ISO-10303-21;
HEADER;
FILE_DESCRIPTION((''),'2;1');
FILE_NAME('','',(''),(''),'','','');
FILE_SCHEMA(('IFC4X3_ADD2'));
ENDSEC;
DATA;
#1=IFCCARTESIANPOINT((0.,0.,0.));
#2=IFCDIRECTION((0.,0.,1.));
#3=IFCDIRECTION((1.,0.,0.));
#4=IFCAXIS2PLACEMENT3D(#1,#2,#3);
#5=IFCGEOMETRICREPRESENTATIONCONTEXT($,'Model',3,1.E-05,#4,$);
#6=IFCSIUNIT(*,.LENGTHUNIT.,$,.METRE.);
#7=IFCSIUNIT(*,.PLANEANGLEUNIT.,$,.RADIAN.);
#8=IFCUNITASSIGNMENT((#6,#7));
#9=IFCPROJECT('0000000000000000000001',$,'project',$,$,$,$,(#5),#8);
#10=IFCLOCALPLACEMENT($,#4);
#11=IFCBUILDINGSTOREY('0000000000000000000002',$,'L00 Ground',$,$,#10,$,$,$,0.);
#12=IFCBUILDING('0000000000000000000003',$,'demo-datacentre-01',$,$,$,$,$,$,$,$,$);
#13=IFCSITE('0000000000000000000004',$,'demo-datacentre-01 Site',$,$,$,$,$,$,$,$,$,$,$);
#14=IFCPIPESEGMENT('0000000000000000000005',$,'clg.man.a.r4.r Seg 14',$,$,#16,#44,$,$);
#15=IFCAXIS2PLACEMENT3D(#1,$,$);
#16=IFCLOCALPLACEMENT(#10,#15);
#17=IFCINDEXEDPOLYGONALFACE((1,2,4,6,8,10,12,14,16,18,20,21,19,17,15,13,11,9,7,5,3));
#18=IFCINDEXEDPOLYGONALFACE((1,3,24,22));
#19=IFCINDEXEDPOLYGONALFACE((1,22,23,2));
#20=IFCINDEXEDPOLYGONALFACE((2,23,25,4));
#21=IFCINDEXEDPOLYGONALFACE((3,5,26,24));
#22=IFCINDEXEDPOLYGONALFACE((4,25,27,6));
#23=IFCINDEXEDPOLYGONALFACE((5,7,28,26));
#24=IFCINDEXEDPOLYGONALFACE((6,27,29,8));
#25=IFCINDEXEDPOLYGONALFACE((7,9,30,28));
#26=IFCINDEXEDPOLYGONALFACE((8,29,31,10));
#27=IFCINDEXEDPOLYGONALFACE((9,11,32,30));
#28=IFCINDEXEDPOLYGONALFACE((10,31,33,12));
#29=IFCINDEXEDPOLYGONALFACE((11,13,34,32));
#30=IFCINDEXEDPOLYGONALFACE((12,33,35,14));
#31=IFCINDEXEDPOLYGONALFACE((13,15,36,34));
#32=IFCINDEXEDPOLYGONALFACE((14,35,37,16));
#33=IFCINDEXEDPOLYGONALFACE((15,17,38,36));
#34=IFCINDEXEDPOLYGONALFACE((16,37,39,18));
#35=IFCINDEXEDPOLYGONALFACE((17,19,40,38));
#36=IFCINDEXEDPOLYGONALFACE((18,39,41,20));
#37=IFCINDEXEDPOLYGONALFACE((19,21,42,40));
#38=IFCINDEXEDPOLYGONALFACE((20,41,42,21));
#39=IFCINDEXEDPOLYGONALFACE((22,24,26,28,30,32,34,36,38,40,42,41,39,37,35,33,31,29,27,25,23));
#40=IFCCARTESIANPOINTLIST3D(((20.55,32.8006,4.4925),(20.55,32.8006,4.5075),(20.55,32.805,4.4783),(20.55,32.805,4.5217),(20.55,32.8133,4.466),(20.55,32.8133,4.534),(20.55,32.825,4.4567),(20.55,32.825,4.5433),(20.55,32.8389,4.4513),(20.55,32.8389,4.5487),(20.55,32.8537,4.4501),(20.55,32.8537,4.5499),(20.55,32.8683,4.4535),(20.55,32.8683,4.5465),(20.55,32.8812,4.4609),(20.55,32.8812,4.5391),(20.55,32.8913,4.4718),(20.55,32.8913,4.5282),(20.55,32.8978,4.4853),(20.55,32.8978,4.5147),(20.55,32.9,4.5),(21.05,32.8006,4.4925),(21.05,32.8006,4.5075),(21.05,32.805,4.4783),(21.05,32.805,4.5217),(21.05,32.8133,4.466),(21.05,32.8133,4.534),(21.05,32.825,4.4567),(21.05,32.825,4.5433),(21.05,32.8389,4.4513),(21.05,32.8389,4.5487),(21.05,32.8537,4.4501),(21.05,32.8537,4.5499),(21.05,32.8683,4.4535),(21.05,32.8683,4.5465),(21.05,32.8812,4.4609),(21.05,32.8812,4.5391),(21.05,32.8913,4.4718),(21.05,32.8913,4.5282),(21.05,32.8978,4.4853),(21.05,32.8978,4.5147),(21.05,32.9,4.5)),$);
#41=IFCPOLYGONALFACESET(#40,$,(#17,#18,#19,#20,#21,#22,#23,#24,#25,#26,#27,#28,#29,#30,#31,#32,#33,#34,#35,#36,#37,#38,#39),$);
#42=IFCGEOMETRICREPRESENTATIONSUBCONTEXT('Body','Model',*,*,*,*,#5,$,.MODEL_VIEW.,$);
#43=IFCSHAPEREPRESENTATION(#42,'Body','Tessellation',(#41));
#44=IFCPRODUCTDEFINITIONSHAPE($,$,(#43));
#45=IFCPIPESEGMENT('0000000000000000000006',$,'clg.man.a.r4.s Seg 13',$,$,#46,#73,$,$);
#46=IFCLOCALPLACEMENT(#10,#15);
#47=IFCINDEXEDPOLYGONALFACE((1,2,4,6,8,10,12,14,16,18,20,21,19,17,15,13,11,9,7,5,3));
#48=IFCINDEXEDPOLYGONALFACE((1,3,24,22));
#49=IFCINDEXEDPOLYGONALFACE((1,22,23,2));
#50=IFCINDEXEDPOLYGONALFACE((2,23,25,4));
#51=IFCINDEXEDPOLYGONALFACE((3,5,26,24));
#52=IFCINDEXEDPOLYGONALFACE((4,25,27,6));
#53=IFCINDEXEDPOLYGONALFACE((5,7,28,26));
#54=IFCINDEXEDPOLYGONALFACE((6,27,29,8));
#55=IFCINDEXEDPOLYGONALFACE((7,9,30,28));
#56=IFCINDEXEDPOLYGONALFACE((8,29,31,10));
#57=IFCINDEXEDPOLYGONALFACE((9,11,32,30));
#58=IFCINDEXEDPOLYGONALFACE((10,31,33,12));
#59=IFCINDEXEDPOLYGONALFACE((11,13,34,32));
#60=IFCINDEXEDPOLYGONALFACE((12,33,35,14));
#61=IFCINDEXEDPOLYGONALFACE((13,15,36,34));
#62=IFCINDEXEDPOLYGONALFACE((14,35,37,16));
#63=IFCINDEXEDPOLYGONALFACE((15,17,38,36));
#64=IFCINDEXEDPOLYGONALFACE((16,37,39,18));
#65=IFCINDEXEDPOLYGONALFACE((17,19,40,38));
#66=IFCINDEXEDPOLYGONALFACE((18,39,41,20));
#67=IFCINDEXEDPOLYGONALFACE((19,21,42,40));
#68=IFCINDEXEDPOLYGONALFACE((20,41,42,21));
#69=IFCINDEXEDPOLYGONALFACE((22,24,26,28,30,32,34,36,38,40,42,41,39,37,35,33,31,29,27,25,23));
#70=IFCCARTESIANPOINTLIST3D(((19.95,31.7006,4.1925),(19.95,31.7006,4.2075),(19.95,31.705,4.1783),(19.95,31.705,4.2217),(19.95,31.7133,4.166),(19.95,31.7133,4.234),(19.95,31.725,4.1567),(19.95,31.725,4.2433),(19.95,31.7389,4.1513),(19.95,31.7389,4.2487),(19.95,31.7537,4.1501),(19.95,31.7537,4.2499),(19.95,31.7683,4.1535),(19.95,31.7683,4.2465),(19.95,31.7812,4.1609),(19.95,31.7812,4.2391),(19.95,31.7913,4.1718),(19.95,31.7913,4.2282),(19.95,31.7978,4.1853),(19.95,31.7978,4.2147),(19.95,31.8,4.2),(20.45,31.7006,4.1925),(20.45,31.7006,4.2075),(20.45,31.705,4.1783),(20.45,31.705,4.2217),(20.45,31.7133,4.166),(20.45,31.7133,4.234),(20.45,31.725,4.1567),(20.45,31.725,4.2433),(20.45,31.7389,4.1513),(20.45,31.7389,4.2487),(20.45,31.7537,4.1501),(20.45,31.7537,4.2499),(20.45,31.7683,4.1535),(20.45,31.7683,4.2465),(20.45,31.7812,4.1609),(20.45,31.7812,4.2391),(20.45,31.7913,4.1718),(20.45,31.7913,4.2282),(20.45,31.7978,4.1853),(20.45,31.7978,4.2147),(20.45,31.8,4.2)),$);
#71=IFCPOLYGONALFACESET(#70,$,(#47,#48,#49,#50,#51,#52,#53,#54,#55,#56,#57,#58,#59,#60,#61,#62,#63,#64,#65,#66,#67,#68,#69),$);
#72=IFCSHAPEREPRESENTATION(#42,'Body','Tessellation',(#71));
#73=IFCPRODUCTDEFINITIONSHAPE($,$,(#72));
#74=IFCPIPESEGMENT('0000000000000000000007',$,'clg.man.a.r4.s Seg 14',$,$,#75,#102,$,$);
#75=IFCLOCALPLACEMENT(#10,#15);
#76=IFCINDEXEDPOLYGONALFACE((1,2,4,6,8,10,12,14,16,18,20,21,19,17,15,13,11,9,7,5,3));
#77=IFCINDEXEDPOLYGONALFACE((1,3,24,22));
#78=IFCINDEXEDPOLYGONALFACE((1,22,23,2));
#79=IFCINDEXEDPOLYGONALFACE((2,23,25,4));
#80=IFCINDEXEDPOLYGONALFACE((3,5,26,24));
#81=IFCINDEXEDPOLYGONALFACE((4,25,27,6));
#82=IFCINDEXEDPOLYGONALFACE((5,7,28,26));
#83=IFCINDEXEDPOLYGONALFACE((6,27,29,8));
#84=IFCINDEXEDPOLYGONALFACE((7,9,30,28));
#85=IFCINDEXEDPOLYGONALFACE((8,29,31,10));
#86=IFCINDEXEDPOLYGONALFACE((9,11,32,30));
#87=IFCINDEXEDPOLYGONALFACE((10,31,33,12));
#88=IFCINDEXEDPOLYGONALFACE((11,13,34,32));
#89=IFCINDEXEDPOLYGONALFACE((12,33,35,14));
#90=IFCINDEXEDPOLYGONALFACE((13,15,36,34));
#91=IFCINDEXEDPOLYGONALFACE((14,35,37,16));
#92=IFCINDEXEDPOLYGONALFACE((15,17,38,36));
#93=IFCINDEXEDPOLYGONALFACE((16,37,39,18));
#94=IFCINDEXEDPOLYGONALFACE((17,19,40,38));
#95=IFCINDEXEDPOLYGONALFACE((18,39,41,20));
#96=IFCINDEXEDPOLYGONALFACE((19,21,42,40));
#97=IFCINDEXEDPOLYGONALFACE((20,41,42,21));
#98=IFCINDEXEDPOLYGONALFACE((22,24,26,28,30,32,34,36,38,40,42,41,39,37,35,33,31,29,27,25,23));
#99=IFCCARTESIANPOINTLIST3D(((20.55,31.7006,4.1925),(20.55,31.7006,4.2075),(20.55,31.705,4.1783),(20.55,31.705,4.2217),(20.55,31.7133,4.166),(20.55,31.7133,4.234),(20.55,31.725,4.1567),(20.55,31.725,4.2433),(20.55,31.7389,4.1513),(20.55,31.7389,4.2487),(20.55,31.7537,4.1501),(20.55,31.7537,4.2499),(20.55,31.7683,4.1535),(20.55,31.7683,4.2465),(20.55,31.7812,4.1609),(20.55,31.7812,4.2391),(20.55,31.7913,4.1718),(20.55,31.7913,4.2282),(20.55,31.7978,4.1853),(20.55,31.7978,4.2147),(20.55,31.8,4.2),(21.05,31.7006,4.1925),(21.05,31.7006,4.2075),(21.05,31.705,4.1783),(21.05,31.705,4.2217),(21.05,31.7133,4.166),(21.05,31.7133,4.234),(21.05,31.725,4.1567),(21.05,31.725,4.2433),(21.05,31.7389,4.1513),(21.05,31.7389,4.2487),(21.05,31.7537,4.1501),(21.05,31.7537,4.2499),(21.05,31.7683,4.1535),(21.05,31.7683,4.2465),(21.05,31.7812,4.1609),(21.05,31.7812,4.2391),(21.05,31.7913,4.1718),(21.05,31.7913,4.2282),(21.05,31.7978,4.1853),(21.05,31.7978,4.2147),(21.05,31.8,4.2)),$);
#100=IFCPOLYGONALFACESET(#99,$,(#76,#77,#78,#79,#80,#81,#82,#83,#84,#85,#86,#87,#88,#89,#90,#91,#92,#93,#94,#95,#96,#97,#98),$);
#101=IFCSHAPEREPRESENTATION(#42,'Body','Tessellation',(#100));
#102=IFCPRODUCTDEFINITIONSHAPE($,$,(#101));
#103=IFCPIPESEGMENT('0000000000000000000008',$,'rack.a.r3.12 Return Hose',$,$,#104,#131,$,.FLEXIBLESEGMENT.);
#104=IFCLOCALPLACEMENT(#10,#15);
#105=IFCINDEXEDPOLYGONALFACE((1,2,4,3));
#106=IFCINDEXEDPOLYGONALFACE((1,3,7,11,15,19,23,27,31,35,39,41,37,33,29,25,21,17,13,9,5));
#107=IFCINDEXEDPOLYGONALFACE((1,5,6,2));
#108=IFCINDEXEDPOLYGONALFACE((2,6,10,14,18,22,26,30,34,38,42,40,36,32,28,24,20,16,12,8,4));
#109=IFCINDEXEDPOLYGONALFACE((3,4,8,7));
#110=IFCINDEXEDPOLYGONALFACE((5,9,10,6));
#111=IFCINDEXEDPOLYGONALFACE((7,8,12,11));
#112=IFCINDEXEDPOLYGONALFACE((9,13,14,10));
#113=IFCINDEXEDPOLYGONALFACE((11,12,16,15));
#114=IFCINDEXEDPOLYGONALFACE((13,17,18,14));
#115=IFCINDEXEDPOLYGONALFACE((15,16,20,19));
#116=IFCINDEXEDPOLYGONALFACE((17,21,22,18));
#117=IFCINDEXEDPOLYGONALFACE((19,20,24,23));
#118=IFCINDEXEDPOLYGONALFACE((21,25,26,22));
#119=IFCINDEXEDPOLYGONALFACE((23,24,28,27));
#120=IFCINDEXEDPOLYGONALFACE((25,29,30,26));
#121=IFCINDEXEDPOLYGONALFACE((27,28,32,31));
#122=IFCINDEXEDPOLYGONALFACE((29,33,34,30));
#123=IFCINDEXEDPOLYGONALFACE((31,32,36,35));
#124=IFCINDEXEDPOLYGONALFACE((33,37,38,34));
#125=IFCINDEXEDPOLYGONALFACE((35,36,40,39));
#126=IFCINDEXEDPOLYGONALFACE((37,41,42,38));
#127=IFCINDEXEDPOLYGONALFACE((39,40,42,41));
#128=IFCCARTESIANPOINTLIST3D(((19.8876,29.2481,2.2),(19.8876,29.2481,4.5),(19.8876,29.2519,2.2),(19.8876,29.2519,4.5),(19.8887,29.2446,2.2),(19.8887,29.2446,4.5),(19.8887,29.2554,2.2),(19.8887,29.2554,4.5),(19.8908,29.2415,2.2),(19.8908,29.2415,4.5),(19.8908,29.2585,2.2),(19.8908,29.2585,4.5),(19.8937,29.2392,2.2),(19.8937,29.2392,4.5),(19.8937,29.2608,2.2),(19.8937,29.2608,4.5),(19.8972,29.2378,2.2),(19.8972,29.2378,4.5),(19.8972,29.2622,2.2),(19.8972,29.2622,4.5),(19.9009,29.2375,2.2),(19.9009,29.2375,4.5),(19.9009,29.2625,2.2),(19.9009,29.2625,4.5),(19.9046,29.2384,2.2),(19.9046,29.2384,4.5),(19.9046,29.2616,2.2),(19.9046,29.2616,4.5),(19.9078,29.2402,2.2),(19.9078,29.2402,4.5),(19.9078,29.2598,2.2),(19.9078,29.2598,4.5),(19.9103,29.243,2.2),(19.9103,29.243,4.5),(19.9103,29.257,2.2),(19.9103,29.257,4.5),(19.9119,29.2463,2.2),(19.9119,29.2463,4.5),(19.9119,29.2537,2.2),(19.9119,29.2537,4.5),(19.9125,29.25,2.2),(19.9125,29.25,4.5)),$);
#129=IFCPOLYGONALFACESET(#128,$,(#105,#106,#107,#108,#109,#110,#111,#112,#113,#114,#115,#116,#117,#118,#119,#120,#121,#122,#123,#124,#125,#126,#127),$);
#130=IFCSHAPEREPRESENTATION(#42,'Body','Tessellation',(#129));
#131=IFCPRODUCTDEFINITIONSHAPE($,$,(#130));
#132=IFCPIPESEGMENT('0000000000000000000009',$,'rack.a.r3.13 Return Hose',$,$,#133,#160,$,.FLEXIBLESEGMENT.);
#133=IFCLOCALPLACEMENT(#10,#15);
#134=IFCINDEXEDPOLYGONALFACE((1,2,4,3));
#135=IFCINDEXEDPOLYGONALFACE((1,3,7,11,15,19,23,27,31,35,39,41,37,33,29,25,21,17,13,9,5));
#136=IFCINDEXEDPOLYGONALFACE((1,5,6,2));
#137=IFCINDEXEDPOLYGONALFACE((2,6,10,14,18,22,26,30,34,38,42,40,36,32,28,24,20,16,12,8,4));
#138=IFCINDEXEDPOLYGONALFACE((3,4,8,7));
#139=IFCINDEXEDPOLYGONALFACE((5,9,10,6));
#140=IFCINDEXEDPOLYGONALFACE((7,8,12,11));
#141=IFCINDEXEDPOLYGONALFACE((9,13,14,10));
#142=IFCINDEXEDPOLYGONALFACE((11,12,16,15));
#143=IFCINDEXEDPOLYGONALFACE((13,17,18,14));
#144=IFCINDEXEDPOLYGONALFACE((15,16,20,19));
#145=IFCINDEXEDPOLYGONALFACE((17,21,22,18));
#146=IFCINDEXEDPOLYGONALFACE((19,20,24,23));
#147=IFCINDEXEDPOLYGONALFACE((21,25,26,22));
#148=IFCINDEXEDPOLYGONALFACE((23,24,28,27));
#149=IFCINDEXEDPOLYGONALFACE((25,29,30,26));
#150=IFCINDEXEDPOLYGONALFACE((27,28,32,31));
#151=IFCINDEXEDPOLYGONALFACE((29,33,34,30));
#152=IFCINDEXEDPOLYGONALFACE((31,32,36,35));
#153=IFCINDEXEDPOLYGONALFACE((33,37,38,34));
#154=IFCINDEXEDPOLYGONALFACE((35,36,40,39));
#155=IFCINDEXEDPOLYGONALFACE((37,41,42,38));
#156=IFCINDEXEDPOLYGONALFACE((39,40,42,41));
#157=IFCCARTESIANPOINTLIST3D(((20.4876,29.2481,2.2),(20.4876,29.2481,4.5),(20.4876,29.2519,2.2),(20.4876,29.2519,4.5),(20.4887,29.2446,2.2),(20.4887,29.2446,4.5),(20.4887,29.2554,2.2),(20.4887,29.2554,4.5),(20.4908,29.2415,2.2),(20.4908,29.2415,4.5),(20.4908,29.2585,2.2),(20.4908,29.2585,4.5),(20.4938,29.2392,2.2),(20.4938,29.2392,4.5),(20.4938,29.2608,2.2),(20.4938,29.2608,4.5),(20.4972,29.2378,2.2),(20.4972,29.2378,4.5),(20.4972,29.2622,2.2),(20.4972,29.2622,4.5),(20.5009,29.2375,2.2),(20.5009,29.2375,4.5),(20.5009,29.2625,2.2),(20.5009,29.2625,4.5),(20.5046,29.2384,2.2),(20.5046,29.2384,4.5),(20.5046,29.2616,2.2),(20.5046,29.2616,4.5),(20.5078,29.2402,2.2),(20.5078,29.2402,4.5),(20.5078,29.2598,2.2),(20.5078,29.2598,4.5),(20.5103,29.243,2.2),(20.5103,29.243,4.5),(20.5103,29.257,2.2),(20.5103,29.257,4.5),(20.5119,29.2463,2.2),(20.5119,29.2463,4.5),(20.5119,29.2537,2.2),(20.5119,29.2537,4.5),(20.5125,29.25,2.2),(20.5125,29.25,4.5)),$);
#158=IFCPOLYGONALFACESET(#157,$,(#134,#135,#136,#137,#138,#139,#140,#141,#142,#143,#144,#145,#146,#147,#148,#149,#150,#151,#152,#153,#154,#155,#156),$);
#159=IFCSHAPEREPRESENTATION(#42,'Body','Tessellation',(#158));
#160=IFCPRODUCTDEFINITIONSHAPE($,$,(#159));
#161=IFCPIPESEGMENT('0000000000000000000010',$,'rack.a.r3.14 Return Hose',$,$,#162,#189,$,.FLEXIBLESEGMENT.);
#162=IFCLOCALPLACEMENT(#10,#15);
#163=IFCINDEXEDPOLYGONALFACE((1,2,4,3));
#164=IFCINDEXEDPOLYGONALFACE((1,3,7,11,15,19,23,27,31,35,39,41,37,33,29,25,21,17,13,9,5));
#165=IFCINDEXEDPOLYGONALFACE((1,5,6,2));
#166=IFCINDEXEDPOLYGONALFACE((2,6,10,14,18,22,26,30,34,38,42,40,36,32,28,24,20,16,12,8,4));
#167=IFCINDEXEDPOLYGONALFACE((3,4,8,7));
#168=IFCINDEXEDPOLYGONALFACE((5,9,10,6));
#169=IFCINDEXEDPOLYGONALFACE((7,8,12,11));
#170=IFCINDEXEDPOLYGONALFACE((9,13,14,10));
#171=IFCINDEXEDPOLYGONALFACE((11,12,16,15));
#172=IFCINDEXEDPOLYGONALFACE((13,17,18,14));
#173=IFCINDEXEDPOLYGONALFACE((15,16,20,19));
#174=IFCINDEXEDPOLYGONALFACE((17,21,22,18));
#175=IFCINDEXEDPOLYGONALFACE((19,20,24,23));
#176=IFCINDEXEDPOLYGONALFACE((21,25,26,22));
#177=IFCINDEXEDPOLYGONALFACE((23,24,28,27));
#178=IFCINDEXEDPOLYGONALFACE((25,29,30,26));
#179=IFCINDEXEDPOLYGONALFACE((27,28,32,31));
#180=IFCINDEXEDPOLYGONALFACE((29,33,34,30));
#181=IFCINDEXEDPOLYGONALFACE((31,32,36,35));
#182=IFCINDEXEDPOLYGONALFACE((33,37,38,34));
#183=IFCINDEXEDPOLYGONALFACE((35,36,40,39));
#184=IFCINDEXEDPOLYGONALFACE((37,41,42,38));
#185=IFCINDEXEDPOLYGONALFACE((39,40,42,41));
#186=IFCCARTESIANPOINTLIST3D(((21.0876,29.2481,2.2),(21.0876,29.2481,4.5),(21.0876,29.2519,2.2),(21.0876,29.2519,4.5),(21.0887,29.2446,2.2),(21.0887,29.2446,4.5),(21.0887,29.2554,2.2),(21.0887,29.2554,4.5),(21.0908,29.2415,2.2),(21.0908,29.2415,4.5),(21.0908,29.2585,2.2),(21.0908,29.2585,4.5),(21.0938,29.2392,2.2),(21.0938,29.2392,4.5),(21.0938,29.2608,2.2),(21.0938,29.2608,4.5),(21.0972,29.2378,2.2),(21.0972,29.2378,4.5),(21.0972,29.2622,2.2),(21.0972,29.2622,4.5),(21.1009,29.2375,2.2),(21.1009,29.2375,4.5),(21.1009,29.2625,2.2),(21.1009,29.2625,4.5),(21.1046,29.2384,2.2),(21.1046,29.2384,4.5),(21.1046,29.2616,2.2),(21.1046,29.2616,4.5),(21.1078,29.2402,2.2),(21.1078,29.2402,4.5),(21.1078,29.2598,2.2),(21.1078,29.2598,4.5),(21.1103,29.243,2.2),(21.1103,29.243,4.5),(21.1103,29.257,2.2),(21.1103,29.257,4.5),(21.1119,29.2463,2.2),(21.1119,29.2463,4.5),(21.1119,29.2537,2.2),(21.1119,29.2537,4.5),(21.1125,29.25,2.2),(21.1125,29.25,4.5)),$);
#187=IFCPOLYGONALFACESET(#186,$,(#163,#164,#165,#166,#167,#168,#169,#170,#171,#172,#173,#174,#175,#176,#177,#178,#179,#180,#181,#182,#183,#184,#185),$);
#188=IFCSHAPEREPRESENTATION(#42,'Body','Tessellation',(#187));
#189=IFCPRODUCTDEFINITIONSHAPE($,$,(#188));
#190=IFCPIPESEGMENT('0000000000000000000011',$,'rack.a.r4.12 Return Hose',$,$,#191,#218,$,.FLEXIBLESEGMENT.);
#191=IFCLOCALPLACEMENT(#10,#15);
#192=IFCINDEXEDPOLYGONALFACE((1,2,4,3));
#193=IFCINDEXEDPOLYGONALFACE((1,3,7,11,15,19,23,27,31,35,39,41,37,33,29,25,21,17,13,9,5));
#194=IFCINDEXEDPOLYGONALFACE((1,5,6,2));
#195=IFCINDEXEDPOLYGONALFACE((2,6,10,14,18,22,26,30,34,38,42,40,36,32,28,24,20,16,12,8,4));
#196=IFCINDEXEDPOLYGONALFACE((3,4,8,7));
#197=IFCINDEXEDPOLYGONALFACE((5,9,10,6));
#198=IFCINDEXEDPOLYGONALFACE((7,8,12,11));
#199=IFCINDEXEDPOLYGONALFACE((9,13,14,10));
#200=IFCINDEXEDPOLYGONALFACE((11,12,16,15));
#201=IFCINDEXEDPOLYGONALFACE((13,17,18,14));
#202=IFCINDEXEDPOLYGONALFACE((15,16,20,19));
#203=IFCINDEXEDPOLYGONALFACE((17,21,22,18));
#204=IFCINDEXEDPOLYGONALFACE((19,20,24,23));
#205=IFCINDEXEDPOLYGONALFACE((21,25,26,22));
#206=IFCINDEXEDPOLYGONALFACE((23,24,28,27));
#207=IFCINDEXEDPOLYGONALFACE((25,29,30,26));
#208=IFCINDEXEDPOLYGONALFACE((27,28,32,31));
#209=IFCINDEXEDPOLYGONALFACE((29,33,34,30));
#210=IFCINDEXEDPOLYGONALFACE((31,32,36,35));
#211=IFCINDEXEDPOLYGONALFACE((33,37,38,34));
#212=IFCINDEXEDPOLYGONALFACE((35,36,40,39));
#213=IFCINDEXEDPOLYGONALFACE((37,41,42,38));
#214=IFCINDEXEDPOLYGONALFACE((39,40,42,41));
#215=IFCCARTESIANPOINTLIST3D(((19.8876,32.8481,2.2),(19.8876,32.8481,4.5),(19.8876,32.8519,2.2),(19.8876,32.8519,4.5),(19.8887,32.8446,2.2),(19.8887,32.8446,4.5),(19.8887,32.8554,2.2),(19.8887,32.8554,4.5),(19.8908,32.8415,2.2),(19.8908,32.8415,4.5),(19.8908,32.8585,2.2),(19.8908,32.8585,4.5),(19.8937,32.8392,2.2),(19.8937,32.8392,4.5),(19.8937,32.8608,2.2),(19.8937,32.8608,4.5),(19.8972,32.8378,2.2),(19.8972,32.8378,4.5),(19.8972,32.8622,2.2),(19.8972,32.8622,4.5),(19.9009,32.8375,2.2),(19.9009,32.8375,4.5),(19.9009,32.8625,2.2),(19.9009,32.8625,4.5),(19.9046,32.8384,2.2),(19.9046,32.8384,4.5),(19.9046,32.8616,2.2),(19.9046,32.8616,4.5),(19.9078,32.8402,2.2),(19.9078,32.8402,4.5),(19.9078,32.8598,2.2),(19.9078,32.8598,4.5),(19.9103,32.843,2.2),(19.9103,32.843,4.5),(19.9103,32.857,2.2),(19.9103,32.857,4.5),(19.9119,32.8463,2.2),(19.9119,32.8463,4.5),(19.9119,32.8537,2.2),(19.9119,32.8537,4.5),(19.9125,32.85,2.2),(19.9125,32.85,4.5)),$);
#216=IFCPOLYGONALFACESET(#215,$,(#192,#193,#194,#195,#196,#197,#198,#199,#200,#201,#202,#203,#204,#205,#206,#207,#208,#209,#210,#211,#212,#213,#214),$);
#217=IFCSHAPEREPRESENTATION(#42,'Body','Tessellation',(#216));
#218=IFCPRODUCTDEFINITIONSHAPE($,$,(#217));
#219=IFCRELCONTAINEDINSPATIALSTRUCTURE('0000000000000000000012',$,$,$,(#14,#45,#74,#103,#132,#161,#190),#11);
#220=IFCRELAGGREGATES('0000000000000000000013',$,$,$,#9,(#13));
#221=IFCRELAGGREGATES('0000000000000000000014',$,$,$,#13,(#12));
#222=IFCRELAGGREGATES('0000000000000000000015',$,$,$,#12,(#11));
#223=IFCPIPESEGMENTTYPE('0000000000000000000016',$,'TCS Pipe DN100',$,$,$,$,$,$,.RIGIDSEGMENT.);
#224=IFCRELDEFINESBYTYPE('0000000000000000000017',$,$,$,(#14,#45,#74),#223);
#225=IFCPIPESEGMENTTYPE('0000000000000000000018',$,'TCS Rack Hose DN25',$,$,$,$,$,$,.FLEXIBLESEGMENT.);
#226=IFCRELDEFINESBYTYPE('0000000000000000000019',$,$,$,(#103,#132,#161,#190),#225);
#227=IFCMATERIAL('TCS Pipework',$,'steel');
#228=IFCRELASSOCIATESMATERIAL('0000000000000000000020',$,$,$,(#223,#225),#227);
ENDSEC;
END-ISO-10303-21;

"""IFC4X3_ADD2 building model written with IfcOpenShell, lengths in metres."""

from ifc_helpers import new_model, si_unit, frame, origin_with_axes, place, context, subcontext, project, spatial, circle, extrude, material, type_object, element, save


model = new_model("IFC4X3_ADD2")

# Units and contexts
model_context = context("Model", 3, precision=1e-05, world=origin_with_axes())
body_context = subcontext(model_context, "Body", "Model", "MODEL_VIEW")
ifc_project = project(units=[si_unit("LENGTHUNIT", "METRE"), si_unit("PLANEANGLEUNIT", "RADIAN")], contexts=[model_context])

# Site, building, storey
site = spatial("IfcSite", under=ifc_project, Name="demo-datacentre-01 Site")
building = spatial("IfcBuilding", under=site, Name="demo-datacentre-01")
storey_placement = place(None, origin_with_axes())
storey = spatial("IfcBuildingStorey", under=building, at=storey_placement, Name="L00 Ground", Elevation=0.0)

# Shared definitions
ifc_material = material(Name="TCS Pipework", Category="steel")

# Pipe segments
pipe_segment_type_1 = type_object("IfcPipeSegmentType", Name="TCS Pipe DN100", PredefinedType="RIGIDSEGMENT", material=ifc_material)
for number, where, z_axis, x_axis, name in (
    (1, (20.55, 32.85, 4.5), (1.0, 0.0, 0.0), (0.0, 1.0, 0.0), "clg.man.a.r4.r Seg 14"),
    (2, (19.95, 31.75, 4.2), (1.0, 0.0, 0.0), (0.0, 1.0, 0.0), "clg.man.a.r4.s Seg 13"),
    (3, (20.55, 31.75, 4.2), (1.0, 0.0, 0.0), (0.0, 1.0, 0.0), "clg.man.a.r4.s Seg 14"),
):
    element("IfcPipeSegment", number, at=place(storey_placement, frame(where, z_axis=z_axis, x_axis=x_axis)), inside=storey, type_object=pipe_segment_type_1, Name=name, context=body_context, shape_type="SweptSolid", body=[
        extrude(circle(Radius=0.05), origin_with_axes(), (0.0, 0.0, 1.0), 0.5),
    ])
pipe_segment_type_2 = type_object("IfcPipeSegmentType", Name="TCS Rack Hose DN25", PredefinedType="FLEXIBLESEGMENT", material=ifc_material)
for number, where, z_axis, x_axis, name in (
    (4, (19.9, 29.25, 4.5), (0.0, 0.0, -1.0), (1.0, 0.0, 0.0), "rack.a.r3.12 Return Hose"),
    (5, (20.5, 29.25, 4.5), (0.0, 0.0, -1.0), (1.0, 0.0, 0.0), "rack.a.r3.13 Return Hose"),
    (6, (21.1, 29.25, 4.5), (0.0, 0.0, -1.0), (1.0, 0.0, 0.0), "rack.a.r3.14 Return Hose"),
    (7, (19.9, 32.85, 4.5), (0.0, 0.0, -1.0), (1.0, 0.0, 0.0), "rack.a.r4.12 Return Hose"),
):
    element("IfcPipeSegment", number, at=place(storey_placement, frame(where, z_axis=z_axis, x_axis=x_axis)), inside=storey, type_object=pipe_segment_type_2, Name=name, PredefinedType="FLEXIBLESEGMENT", context=body_context, shape_type="SweptSolid", body=[
        extrude(circle(Radius=0.0125), origin_with_axes(), (0.0, 0.0, 1.0), 2.3),
    ])

save(model, "model.ifc")
